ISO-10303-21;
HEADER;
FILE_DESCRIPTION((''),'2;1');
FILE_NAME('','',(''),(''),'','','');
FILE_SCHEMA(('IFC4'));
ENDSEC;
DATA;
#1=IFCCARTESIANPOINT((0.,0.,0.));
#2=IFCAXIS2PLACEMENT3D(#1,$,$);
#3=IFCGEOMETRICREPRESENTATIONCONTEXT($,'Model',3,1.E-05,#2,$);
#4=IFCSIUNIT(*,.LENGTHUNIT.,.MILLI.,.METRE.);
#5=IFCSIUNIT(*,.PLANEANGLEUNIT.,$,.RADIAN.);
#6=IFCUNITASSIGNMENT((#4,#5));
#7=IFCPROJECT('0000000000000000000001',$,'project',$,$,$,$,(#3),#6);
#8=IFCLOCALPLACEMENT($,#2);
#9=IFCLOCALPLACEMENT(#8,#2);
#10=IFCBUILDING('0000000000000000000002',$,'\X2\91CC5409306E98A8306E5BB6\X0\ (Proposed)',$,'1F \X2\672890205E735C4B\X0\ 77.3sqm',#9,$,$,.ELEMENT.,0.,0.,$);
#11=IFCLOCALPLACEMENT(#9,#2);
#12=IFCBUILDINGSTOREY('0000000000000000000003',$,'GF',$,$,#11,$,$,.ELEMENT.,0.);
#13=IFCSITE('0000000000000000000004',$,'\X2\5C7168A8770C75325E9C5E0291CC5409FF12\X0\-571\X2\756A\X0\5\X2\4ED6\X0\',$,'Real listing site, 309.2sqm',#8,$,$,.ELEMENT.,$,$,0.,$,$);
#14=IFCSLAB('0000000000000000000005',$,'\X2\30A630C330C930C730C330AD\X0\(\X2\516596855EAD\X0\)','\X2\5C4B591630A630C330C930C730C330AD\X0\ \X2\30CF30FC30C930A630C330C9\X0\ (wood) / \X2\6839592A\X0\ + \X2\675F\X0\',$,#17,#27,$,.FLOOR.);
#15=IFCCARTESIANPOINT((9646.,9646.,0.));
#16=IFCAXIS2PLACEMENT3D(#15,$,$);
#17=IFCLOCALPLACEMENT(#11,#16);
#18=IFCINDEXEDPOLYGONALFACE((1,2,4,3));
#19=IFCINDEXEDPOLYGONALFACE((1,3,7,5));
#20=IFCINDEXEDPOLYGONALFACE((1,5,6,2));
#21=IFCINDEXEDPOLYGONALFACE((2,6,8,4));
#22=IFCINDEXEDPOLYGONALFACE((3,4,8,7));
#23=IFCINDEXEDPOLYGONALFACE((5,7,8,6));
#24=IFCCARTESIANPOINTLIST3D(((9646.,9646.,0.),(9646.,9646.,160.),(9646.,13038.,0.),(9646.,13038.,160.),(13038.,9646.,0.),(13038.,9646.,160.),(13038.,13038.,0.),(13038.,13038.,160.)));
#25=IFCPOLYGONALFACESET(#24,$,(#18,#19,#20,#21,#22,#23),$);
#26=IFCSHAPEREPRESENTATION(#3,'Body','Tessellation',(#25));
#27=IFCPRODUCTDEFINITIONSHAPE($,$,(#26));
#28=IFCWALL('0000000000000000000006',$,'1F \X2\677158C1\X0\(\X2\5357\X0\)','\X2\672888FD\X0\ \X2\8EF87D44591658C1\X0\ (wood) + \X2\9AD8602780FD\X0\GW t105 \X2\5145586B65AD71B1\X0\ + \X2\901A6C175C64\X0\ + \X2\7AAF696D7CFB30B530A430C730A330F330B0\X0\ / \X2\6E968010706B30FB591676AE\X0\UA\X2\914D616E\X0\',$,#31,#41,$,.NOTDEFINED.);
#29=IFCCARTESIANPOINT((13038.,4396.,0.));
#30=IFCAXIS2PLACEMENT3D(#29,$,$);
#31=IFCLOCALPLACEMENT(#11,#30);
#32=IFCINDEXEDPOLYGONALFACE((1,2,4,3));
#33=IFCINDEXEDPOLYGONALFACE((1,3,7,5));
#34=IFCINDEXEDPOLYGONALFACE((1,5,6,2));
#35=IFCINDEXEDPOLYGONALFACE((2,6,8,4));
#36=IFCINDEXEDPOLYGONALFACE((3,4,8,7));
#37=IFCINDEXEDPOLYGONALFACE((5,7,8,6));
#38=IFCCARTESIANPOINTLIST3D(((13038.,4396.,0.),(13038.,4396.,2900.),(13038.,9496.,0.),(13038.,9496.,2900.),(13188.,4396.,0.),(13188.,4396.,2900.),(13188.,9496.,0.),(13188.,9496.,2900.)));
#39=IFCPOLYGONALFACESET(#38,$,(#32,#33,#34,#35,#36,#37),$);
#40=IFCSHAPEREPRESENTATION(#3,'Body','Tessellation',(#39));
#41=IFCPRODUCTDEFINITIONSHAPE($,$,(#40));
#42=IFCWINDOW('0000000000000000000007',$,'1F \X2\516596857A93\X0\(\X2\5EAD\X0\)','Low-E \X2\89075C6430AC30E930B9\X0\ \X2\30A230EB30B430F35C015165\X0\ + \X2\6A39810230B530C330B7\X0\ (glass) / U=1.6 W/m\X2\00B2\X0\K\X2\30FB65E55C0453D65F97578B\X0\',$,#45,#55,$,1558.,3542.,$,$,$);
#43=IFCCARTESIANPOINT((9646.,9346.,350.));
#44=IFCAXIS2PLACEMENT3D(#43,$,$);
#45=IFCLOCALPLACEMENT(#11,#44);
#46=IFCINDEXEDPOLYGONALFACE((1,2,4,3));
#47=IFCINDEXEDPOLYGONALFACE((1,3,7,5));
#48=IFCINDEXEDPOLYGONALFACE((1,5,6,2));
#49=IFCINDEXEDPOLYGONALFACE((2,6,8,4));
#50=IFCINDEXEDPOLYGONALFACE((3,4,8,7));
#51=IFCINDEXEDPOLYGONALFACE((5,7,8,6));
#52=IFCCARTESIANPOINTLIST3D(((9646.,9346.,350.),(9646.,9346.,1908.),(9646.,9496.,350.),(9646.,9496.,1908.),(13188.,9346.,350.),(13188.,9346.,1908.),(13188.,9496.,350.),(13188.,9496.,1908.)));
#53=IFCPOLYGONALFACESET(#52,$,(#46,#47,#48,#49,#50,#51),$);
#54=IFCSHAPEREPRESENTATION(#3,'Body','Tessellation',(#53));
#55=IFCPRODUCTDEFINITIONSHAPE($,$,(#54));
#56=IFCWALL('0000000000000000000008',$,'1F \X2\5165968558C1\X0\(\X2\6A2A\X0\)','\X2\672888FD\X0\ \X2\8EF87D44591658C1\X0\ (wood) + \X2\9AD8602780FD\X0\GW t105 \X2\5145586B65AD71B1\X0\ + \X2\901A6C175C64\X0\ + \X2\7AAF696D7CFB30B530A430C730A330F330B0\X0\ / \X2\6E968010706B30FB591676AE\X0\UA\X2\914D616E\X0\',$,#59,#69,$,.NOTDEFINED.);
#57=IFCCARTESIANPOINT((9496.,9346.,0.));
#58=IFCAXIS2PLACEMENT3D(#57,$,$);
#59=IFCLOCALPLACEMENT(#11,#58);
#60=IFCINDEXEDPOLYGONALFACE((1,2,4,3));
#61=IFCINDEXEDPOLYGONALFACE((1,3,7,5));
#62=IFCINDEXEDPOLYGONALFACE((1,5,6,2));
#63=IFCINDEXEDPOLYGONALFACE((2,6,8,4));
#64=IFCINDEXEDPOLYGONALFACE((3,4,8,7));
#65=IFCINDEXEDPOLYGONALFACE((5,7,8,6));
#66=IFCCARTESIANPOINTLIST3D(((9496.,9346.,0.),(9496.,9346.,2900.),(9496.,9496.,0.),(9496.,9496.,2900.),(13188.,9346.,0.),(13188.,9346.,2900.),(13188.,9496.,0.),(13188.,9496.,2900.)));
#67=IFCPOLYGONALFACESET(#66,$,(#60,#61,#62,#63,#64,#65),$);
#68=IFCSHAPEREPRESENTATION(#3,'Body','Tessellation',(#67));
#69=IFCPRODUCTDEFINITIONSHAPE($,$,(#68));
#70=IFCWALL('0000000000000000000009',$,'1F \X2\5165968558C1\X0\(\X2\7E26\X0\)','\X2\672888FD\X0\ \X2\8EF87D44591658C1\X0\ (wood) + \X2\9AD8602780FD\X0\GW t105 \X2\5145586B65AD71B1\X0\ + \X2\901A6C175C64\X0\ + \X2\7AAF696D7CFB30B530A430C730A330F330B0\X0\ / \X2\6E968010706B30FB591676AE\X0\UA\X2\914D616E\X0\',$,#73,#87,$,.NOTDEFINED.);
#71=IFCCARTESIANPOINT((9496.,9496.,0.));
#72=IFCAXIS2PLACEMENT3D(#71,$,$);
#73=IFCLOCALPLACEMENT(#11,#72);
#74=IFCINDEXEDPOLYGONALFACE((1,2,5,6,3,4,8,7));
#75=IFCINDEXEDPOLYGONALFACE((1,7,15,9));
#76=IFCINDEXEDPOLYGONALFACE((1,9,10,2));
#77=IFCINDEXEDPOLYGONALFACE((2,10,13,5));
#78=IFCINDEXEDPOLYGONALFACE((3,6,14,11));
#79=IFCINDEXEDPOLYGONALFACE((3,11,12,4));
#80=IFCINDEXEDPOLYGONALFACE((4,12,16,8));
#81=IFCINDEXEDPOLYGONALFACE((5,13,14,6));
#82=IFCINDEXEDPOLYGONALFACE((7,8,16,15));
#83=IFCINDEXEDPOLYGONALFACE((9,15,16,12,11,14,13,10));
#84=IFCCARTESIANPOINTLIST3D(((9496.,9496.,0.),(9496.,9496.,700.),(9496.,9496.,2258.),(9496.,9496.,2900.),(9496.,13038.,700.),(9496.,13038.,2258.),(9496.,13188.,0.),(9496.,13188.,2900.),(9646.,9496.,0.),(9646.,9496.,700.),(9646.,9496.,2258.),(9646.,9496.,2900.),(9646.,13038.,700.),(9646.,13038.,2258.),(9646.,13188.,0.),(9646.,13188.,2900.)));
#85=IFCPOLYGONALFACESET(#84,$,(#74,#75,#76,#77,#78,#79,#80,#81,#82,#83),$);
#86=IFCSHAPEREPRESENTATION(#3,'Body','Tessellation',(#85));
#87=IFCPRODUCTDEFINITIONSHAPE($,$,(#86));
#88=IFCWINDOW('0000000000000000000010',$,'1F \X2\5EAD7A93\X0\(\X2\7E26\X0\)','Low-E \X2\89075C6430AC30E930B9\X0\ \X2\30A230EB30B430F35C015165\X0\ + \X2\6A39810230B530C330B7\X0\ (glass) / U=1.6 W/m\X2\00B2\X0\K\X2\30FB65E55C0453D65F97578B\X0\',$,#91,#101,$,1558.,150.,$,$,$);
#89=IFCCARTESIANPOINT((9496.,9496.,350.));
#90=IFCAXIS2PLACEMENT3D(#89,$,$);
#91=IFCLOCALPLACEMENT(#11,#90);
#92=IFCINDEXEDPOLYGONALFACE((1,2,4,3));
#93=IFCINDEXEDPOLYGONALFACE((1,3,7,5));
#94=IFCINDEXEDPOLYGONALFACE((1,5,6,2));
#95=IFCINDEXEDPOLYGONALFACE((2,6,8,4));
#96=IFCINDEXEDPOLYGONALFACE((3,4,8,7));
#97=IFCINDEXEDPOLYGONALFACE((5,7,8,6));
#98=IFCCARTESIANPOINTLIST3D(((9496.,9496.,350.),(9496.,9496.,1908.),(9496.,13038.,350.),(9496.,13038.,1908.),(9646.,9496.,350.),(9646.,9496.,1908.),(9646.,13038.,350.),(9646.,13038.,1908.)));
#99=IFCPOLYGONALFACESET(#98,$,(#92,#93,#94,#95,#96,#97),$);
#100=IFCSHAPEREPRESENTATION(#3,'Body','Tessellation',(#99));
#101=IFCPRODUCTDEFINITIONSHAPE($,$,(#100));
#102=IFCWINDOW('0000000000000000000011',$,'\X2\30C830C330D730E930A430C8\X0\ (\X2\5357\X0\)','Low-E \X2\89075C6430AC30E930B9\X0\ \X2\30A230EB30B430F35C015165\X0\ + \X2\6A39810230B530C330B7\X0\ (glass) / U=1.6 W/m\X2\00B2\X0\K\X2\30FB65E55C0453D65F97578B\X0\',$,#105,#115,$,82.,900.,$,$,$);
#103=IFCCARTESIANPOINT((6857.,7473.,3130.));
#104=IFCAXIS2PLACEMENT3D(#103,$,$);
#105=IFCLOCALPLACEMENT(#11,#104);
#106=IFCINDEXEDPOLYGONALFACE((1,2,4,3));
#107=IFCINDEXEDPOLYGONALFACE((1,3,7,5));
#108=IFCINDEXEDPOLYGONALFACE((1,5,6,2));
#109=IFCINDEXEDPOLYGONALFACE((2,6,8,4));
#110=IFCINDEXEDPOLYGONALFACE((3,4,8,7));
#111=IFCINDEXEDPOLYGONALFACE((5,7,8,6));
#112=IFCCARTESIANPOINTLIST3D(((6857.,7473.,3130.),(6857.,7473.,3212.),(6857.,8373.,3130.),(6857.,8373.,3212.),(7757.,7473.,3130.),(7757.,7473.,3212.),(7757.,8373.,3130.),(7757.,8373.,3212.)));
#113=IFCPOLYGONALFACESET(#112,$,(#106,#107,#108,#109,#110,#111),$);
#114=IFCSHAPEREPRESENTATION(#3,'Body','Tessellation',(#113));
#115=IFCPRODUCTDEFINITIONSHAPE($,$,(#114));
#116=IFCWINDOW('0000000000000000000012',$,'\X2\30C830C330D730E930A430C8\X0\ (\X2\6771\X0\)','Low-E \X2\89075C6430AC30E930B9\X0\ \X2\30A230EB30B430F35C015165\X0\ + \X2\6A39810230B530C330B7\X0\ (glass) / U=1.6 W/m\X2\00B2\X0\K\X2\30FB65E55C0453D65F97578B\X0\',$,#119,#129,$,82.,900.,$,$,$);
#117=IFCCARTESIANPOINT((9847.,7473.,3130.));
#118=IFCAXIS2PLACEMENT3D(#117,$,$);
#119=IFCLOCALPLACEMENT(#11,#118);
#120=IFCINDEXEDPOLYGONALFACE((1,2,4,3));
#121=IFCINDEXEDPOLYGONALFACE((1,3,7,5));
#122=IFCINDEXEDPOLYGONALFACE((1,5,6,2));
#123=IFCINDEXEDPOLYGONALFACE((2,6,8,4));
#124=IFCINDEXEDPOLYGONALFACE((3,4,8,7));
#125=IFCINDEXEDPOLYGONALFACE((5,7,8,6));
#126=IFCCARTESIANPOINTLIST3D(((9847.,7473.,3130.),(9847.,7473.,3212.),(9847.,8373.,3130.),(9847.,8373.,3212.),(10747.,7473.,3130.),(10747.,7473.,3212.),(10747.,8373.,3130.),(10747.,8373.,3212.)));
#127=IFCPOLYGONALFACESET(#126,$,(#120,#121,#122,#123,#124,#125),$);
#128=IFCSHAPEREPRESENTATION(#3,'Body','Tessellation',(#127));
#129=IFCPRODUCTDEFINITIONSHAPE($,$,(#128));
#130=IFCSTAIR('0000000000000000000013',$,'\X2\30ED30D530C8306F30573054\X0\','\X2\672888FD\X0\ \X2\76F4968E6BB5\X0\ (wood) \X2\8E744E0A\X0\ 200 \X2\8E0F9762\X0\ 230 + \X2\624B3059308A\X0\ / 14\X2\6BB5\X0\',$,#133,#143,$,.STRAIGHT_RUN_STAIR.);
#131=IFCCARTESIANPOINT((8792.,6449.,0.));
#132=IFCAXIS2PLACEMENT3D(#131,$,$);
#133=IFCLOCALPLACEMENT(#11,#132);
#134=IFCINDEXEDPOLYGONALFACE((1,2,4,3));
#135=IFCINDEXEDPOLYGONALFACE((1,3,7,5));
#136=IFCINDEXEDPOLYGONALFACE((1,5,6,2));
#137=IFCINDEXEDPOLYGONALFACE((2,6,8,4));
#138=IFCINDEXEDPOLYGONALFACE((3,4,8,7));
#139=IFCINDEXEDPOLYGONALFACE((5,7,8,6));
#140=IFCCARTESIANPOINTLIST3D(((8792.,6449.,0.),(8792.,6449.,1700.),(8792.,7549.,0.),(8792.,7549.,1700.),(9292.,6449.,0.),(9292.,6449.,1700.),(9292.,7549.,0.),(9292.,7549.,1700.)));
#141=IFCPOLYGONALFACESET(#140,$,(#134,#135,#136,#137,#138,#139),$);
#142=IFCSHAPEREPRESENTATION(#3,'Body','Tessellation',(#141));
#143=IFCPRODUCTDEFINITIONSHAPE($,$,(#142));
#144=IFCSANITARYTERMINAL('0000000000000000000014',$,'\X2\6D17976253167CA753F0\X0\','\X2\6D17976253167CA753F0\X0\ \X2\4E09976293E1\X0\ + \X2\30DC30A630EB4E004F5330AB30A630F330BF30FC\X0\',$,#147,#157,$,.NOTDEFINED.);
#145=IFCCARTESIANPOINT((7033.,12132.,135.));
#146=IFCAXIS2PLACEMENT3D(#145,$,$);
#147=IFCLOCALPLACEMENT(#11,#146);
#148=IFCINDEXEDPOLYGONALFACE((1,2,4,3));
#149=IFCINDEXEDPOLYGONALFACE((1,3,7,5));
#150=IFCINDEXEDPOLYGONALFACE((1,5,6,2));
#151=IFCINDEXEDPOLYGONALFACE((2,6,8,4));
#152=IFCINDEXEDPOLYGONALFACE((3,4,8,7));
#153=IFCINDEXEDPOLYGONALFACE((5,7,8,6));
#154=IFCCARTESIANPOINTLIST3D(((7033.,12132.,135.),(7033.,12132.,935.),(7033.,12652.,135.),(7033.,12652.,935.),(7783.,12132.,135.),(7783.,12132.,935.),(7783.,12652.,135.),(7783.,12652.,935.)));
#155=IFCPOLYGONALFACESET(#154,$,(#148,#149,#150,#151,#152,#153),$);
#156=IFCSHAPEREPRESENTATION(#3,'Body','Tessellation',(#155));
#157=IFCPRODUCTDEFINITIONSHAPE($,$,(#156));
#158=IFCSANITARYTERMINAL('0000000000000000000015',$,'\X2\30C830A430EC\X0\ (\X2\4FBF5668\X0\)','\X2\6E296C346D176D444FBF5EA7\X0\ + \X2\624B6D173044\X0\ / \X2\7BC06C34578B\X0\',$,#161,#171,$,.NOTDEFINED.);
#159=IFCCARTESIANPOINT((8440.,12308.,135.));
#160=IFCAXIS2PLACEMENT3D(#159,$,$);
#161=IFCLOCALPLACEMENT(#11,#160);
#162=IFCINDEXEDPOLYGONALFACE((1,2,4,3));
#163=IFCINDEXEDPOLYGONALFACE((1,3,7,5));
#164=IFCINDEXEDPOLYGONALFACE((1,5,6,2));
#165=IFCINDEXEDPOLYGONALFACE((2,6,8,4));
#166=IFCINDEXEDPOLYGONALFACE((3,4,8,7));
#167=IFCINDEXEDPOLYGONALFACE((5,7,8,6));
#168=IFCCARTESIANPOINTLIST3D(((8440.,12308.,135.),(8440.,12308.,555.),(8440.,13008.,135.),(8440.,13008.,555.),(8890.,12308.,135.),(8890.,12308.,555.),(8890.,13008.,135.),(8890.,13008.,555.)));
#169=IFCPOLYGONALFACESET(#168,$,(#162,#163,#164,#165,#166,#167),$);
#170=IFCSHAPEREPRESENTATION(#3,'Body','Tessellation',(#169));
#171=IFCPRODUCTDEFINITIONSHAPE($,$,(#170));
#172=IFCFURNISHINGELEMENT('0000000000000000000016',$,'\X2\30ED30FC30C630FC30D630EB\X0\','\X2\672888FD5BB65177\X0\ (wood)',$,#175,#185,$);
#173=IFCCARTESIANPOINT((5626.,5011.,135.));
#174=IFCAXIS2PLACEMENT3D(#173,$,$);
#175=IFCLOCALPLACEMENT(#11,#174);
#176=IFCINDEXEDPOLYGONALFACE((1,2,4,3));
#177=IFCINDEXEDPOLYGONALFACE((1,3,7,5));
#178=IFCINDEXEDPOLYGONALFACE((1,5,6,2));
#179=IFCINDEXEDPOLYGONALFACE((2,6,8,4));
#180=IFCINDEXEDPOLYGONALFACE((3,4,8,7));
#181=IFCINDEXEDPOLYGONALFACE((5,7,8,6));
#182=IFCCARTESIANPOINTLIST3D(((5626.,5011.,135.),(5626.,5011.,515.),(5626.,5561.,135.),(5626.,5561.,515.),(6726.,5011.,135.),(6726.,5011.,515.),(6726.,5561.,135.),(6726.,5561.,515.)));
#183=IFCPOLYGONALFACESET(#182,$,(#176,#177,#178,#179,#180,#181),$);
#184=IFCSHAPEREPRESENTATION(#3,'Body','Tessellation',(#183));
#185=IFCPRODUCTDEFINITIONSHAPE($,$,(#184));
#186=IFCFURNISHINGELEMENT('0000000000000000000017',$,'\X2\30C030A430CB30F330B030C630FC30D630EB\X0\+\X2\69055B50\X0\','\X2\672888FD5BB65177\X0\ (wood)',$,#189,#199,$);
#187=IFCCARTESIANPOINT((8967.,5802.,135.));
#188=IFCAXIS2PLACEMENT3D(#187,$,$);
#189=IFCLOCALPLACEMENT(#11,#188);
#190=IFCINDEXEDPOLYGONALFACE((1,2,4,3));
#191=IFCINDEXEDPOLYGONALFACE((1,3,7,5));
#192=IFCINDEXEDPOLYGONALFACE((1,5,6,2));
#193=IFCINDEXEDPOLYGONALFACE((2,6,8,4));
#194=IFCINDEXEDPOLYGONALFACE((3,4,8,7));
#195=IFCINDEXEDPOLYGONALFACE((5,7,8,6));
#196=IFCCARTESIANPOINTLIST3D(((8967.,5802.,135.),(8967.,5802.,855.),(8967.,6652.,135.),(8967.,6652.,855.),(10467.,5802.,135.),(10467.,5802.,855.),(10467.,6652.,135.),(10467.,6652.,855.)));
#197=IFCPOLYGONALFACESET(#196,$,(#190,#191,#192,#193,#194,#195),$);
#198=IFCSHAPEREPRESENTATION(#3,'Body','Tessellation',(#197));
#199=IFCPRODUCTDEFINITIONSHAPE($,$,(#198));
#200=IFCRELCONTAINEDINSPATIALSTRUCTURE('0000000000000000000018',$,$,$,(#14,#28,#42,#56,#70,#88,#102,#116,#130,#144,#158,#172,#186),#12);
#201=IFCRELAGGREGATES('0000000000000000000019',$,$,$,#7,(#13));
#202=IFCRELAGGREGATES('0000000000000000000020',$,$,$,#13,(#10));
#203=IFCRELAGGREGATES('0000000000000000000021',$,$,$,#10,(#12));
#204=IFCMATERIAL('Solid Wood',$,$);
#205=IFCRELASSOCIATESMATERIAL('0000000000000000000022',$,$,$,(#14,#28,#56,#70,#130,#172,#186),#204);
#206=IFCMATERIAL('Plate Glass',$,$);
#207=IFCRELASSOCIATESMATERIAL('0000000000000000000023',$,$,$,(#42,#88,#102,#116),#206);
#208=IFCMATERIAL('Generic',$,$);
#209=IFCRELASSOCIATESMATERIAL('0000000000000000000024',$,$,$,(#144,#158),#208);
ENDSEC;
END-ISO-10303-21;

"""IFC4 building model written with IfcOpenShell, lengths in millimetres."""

from ifc_helpers import new_model, si_unit, frame, frame_2d, origin, place, context, project, spatial, rectangle, extrude, material, element, fill, save


model = new_model("IFC4")

# Units and contexts
model_context = context("Model", 3, precision=1e-05, world=origin())
ifc_project = project(units=[si_unit("LENGTHUNIT", "METRE", prefix="MILLI"), si_unit("PLANEANGLEUNIT", "RADIAN")], contexts=[model_context])

# Site, building, storey
site_placement = place(None, origin())
site = spatial("IfcSite", under=ifc_project, at=site_placement, Name="山梨県甲府市里吉２-571番5他", ObjectType="Real listing site, 309.2sqm", CompositionType="ELEMENT", RefElevation=0.0)
building_placement = place(site_placement, origin())
building = spatial("IfcBuilding", under=site, at=building_placement, Name="里吉の風の家 (Proposed)", ObjectType="1F 木造平屋 77.3sqm", CompositionType="ELEMENT", ElevationOfRefHeight=0.0, ElevationOfTerrain=0.0)
storey_placement = place(building_placement, origin())
storey = spatial("IfcBuildingStorey", under=building, at=storey_placement, Name="GF", CompositionType="ELEMENT", Elevation=0.0)

# Slab
ifc_material_1 = material(Name="Solid Wood")
slab_placement = place(storey_placement, frame((9646.0, 9646.0, 0.0)))
element("IfcSlab", 1, at=slab_placement, inside=storey, material=ifc_material_1, Name="ウッドデッキ(入隅庭)", Description="屋外ウッドデッキ ハードウッド (wood) / 根太 + 束", PredefinedType="FLOOR", context=model_context, shape_type="SweptSolid", body=[
    extrude(rectangle(XDim=3392.0, YDim=3392.0, at=frame_2d((1696.0, 1696.0))), frame((9646.0, 9646.0, 0.0)), (0.0, 0.0, 1.0), 160.0),
])

# Wall, opening, window
wall_1_placement = place(storey_placement, frame((13038.0, 4396.0, 0.0)))
wall_1 = element("IfcWall", 2, at=wall_1_placement, inside=storey, material=ifc_material_1, Name="1F 東壁(南)", Description="木製 軸組外壁 (wood) + 高性能GW t105 充填断熱 + 通気層 + 窯業系サイディング / 準耐火・外皮UA配慮", PredefinedType="NOTDEFINED", context=model_context, shape_type="SweptSolid", body=[
    extrude(rectangle(XDim=150.0, YDim=5100.0, at=frame_2d((75.0, 2550.0))), frame((13038.0, 4396.0, 0.0)), (0.0, 0.0, 1.0), 2900.0),
])
opening_1_placement = place(storey_placement, frame((9646.0, 9346.0, 350.0)))
opening_1 = element("IfcOpeningElement", 3, at=opening_1_placement, cuts=wall_1, PredefinedType="NOTDEFINED", context=model_context, shape_type="SweptSolid", body=[
    extrude(rectangle(XDim=3542.0, YDim=150.0, at=frame_2d((1771.0, 75.0))), frame((9646.0, 9346.0, 350.0)), (0.0, 0.0, 1.0), 1558.0),
])
ifc_material_2 = material(Name="Plate Glass")
window_1_placement = place(storey_placement, frame((9646.0, 9346.0, 350.0)))
window_1 = element("IfcWindow", 4, at=window_1_placement, inside=storey, material=ifc_material_2, Name="1F 入隅窓(庭)", Description="Low-E 複層ガラス アルゴン封入 + 樹脂サッシ (glass) / U=1.6 W/m²K・日射取得型", OverallHeight=1558.0, OverallWidth=3542.0, context=model_context, shape_type="SweptSolid", body=[
    extrude(rectangle(XDim=3542.0, YDim=150.0, at=frame_2d((1771.0, 75.0))), frame((9646.0, 9346.0, 350.0)), (0.0, 0.0, 1.0), 1558.0),
])
fill(opening_1, window_1)

# Wall
wall_2_placement = place(storey_placement, frame((9496.0, 9346.0, 0.0)))
element("IfcWall", 5, at=wall_2_placement, inside=storey, material=ifc_material_1, Name="1F 入隅壁(横)", Description="木製 軸組外壁 (wood) + 高性能GW t105 充填断熱 + 通気層 + 窯業系サイディング / 準耐火・外皮UA配慮", PredefinedType="NOTDEFINED", context=model_context, shape_type="SweptSolid", body=[
    extrude(rectangle(XDim=3692.0, YDim=150.0, at=frame_2d((1846.0, 75.0))), frame((9496.0, 9346.0, 0.0)), (0.0, 0.0, 1.0), 2900.0),
])

# Wall, opening, window
wall_3_placement = place(storey_placement, frame((9496.0, 9496.0, 0.0)))
wall_3 = element("IfcWall", 6, at=wall_3_placement, inside=storey, material=ifc_material_1, Name="1F 入隅壁(縦)", Description="木製 軸組外壁 (wood) + 高性能GW t105 充填断熱 + 通気層 + 窯業系サイディング / 準耐火・外皮UA配慮", PredefinedType="NOTDEFINED", context=model_context, shape_type="SweptSolid", body=[
    extrude(rectangle(XDim=150.0, YDim=3692.0, at=frame_2d((75.0, 1846.0))), frame((9496.0, 9496.0, 0.0)), (0.0, 0.0, 1.0), 2900.0),
])
opening_2_placement = place(storey_placement, frame((9496.0, 9496.0, 350.0)))
opening_2 = element("IfcOpeningElement", 7, at=opening_2_placement, cuts=wall_3, PredefinedType="NOTDEFINED", context=model_context, shape_type="SweptSolid", body=[
    extrude(rectangle(XDim=150.0, YDim=3542.0, at=frame_2d((75.0, 1771.0))), frame((9496.0, 9496.0, 350.0)), (0.0, 0.0, 1.0), 1558.0),
])
window_2_placement = place(storey_placement, frame((9496.0, 9496.0, 350.0)))
window_2 = element("IfcWindow", 8, at=window_2_placement, inside=storey, material=ifc_material_2, Name="1F 庭窓(縦)", Description="Low-E 複層ガラス アルゴン封入 + 樹脂サッシ (glass) / U=1.6 W/m²K・日射取得型", OverallHeight=1558.0, OverallWidth=150.0, context=model_context, shape_type="SweptSolid", body=[
    extrude(rectangle(XDim=150.0, YDim=3542.0, at=frame_2d((75.0, 1771.0))), frame((9496.0, 9496.0, 350.0)), (0.0, 0.0, 1.0), 1558.0),
])
fill(opening_2, window_2)

# Windows
window_3_placement = place(storey_placement, frame((6857.0, 7473.0, 3130.0)))
element("IfcWindow", 9, at=window_3_placement, inside=storey, material=ifc_material_2, Name="トップライト (南)", Description="Low-E 複層ガラス アルゴン封入 + 樹脂サッシ (glass) / U=1.6 W/m²K・日射取得型", OverallHeight=82.0, OverallWidth=900.0, context=model_context, shape_type="SweptSolid", body=[
    extrude(rectangle(XDim=900.0, YDim=900.0, at=frame_2d((450.0, 450.0))), frame((6857.0, 7473.0, 3130.0)), (0.0, 0.0, 1.0), 82.0),
])
window_4_placement = place(storey_placement, frame((9847.0, 7473.0, 3130.0)))
element("IfcWindow", 10, at=window_4_placement, inside=storey, material=ifc_material_2, Name="トップライト (東)", Description="Low-E 複層ガラス アルゴン封入 + 樹脂サッシ (glass) / U=1.6 W/m²K・日射取得型", OverallHeight=82.0, OverallWidth=900.0, context=model_context, shape_type="SweptSolid", body=[
    extrude(rectangle(XDim=900.0, YDim=900.0, at=frame_2d((450.0, 450.0))), frame((9847.0, 7473.0, 3130.0)), (0.0, 0.0, 1.0), 82.0),
])

# Stair
stair_placement = place(storey_placement, frame((8792.0, 6449.0, 0.0)))
element("IfcStair", 11, at=stair_placement, inside=storey, material=ifc_material_1, Name="ロフトはしご", Description="木製 直階段 (wood) 蹴上 200 踏面 230 + 手すり / 14段", PredefinedType="STRAIGHT_RUN_STAIR", context=model_context, shape_type="SweptSolid", body=[
    extrude(rectangle(XDim=500.0, YDim=1100.0, at=frame_2d((250.0, 550.0))), frame((8792.0, 6449.0, 0.0)), (0.0, 0.0, 1.0), 1700.0),
])

# Sanitary terminals
ifc_material_3 = material(Name="Generic")
sanitary_terminal_1_placement = place(storey_placement, frame((7033.0, 12132.0, 135.0)))
element("IfcSanitaryTerminal", 12, at=sanitary_terminal_1_placement, inside=storey, material=ifc_material_3, Name="洗面化粧台", Description="洗面化粧台 三面鏡 + ボウル一体カウンター", PredefinedType="NOTDEFINED", context=model_context, shape_type="SweptSolid", body=[
    extrude(rectangle(XDim=750.0, YDim=520.0, at=frame_2d((375.0, 260.0))), frame((7033.0, 12132.0, 135.0)), (0.0, 0.0, 1.0), 800.0),
])
sanitary_terminal_2_placement = place(storey_placement, frame((8440.0, 12308.0, 135.0)))
element("IfcSanitaryTerminal", 13, at=sanitary_terminal_2_placement, inside=storey, material=ifc_material_3, Name="トイレ (便器)", Description="温水洗浄便座 + 手洗い / 節水型", PredefinedType="NOTDEFINED", context=model_context, shape_type="SweptSolid", body=[
    extrude(rectangle(XDim=450.0, YDim=700.0, at=frame_2d((225.0, 350.0))), frame((8440.0, 12308.0, 135.0)), (0.0, 0.0, 1.0), 420.0),
])

# Furnishing elements
furnishing_1_placement = place(storey_placement, frame((5626.0, 5011.0, 135.0)))
element("IfcFurnishingElement", 14, at=furnishing_1_placement, inside=storey, material=ifc_material_1, Name="ローテーブル", Description="木製家具 (wood)", context=model_context, shape_type="SweptSolid", body=[
    extrude(rectangle(XDim=1100.0, YDim=550.0, at=frame_2d((550.0, 275.0))), frame((5626.0, 5011.0, 135.0)), (0.0, 0.0, 1.0), 380.0),
])
furnishing_2_placement = place(storey_placement, frame((8967.0, 5802.0, 135.0)))
element("IfcFurnishingElement", 15, at=furnishing_2_placement, inside=storey, material=ifc_material_1, Name="ダイニングテーブル+椅子", Description="木製家具 (wood)", context=model_context, shape_type="SweptSolid", body=[
    extrude(rectangle(XDim=1500.0, YDim=850.0, at=frame_2d((750.0, 425.0))), frame((8967.0, 5802.0, 135.0)), (0.0, 0.0, 1.0), 720.0),
])

save(model, "model.ifc")
